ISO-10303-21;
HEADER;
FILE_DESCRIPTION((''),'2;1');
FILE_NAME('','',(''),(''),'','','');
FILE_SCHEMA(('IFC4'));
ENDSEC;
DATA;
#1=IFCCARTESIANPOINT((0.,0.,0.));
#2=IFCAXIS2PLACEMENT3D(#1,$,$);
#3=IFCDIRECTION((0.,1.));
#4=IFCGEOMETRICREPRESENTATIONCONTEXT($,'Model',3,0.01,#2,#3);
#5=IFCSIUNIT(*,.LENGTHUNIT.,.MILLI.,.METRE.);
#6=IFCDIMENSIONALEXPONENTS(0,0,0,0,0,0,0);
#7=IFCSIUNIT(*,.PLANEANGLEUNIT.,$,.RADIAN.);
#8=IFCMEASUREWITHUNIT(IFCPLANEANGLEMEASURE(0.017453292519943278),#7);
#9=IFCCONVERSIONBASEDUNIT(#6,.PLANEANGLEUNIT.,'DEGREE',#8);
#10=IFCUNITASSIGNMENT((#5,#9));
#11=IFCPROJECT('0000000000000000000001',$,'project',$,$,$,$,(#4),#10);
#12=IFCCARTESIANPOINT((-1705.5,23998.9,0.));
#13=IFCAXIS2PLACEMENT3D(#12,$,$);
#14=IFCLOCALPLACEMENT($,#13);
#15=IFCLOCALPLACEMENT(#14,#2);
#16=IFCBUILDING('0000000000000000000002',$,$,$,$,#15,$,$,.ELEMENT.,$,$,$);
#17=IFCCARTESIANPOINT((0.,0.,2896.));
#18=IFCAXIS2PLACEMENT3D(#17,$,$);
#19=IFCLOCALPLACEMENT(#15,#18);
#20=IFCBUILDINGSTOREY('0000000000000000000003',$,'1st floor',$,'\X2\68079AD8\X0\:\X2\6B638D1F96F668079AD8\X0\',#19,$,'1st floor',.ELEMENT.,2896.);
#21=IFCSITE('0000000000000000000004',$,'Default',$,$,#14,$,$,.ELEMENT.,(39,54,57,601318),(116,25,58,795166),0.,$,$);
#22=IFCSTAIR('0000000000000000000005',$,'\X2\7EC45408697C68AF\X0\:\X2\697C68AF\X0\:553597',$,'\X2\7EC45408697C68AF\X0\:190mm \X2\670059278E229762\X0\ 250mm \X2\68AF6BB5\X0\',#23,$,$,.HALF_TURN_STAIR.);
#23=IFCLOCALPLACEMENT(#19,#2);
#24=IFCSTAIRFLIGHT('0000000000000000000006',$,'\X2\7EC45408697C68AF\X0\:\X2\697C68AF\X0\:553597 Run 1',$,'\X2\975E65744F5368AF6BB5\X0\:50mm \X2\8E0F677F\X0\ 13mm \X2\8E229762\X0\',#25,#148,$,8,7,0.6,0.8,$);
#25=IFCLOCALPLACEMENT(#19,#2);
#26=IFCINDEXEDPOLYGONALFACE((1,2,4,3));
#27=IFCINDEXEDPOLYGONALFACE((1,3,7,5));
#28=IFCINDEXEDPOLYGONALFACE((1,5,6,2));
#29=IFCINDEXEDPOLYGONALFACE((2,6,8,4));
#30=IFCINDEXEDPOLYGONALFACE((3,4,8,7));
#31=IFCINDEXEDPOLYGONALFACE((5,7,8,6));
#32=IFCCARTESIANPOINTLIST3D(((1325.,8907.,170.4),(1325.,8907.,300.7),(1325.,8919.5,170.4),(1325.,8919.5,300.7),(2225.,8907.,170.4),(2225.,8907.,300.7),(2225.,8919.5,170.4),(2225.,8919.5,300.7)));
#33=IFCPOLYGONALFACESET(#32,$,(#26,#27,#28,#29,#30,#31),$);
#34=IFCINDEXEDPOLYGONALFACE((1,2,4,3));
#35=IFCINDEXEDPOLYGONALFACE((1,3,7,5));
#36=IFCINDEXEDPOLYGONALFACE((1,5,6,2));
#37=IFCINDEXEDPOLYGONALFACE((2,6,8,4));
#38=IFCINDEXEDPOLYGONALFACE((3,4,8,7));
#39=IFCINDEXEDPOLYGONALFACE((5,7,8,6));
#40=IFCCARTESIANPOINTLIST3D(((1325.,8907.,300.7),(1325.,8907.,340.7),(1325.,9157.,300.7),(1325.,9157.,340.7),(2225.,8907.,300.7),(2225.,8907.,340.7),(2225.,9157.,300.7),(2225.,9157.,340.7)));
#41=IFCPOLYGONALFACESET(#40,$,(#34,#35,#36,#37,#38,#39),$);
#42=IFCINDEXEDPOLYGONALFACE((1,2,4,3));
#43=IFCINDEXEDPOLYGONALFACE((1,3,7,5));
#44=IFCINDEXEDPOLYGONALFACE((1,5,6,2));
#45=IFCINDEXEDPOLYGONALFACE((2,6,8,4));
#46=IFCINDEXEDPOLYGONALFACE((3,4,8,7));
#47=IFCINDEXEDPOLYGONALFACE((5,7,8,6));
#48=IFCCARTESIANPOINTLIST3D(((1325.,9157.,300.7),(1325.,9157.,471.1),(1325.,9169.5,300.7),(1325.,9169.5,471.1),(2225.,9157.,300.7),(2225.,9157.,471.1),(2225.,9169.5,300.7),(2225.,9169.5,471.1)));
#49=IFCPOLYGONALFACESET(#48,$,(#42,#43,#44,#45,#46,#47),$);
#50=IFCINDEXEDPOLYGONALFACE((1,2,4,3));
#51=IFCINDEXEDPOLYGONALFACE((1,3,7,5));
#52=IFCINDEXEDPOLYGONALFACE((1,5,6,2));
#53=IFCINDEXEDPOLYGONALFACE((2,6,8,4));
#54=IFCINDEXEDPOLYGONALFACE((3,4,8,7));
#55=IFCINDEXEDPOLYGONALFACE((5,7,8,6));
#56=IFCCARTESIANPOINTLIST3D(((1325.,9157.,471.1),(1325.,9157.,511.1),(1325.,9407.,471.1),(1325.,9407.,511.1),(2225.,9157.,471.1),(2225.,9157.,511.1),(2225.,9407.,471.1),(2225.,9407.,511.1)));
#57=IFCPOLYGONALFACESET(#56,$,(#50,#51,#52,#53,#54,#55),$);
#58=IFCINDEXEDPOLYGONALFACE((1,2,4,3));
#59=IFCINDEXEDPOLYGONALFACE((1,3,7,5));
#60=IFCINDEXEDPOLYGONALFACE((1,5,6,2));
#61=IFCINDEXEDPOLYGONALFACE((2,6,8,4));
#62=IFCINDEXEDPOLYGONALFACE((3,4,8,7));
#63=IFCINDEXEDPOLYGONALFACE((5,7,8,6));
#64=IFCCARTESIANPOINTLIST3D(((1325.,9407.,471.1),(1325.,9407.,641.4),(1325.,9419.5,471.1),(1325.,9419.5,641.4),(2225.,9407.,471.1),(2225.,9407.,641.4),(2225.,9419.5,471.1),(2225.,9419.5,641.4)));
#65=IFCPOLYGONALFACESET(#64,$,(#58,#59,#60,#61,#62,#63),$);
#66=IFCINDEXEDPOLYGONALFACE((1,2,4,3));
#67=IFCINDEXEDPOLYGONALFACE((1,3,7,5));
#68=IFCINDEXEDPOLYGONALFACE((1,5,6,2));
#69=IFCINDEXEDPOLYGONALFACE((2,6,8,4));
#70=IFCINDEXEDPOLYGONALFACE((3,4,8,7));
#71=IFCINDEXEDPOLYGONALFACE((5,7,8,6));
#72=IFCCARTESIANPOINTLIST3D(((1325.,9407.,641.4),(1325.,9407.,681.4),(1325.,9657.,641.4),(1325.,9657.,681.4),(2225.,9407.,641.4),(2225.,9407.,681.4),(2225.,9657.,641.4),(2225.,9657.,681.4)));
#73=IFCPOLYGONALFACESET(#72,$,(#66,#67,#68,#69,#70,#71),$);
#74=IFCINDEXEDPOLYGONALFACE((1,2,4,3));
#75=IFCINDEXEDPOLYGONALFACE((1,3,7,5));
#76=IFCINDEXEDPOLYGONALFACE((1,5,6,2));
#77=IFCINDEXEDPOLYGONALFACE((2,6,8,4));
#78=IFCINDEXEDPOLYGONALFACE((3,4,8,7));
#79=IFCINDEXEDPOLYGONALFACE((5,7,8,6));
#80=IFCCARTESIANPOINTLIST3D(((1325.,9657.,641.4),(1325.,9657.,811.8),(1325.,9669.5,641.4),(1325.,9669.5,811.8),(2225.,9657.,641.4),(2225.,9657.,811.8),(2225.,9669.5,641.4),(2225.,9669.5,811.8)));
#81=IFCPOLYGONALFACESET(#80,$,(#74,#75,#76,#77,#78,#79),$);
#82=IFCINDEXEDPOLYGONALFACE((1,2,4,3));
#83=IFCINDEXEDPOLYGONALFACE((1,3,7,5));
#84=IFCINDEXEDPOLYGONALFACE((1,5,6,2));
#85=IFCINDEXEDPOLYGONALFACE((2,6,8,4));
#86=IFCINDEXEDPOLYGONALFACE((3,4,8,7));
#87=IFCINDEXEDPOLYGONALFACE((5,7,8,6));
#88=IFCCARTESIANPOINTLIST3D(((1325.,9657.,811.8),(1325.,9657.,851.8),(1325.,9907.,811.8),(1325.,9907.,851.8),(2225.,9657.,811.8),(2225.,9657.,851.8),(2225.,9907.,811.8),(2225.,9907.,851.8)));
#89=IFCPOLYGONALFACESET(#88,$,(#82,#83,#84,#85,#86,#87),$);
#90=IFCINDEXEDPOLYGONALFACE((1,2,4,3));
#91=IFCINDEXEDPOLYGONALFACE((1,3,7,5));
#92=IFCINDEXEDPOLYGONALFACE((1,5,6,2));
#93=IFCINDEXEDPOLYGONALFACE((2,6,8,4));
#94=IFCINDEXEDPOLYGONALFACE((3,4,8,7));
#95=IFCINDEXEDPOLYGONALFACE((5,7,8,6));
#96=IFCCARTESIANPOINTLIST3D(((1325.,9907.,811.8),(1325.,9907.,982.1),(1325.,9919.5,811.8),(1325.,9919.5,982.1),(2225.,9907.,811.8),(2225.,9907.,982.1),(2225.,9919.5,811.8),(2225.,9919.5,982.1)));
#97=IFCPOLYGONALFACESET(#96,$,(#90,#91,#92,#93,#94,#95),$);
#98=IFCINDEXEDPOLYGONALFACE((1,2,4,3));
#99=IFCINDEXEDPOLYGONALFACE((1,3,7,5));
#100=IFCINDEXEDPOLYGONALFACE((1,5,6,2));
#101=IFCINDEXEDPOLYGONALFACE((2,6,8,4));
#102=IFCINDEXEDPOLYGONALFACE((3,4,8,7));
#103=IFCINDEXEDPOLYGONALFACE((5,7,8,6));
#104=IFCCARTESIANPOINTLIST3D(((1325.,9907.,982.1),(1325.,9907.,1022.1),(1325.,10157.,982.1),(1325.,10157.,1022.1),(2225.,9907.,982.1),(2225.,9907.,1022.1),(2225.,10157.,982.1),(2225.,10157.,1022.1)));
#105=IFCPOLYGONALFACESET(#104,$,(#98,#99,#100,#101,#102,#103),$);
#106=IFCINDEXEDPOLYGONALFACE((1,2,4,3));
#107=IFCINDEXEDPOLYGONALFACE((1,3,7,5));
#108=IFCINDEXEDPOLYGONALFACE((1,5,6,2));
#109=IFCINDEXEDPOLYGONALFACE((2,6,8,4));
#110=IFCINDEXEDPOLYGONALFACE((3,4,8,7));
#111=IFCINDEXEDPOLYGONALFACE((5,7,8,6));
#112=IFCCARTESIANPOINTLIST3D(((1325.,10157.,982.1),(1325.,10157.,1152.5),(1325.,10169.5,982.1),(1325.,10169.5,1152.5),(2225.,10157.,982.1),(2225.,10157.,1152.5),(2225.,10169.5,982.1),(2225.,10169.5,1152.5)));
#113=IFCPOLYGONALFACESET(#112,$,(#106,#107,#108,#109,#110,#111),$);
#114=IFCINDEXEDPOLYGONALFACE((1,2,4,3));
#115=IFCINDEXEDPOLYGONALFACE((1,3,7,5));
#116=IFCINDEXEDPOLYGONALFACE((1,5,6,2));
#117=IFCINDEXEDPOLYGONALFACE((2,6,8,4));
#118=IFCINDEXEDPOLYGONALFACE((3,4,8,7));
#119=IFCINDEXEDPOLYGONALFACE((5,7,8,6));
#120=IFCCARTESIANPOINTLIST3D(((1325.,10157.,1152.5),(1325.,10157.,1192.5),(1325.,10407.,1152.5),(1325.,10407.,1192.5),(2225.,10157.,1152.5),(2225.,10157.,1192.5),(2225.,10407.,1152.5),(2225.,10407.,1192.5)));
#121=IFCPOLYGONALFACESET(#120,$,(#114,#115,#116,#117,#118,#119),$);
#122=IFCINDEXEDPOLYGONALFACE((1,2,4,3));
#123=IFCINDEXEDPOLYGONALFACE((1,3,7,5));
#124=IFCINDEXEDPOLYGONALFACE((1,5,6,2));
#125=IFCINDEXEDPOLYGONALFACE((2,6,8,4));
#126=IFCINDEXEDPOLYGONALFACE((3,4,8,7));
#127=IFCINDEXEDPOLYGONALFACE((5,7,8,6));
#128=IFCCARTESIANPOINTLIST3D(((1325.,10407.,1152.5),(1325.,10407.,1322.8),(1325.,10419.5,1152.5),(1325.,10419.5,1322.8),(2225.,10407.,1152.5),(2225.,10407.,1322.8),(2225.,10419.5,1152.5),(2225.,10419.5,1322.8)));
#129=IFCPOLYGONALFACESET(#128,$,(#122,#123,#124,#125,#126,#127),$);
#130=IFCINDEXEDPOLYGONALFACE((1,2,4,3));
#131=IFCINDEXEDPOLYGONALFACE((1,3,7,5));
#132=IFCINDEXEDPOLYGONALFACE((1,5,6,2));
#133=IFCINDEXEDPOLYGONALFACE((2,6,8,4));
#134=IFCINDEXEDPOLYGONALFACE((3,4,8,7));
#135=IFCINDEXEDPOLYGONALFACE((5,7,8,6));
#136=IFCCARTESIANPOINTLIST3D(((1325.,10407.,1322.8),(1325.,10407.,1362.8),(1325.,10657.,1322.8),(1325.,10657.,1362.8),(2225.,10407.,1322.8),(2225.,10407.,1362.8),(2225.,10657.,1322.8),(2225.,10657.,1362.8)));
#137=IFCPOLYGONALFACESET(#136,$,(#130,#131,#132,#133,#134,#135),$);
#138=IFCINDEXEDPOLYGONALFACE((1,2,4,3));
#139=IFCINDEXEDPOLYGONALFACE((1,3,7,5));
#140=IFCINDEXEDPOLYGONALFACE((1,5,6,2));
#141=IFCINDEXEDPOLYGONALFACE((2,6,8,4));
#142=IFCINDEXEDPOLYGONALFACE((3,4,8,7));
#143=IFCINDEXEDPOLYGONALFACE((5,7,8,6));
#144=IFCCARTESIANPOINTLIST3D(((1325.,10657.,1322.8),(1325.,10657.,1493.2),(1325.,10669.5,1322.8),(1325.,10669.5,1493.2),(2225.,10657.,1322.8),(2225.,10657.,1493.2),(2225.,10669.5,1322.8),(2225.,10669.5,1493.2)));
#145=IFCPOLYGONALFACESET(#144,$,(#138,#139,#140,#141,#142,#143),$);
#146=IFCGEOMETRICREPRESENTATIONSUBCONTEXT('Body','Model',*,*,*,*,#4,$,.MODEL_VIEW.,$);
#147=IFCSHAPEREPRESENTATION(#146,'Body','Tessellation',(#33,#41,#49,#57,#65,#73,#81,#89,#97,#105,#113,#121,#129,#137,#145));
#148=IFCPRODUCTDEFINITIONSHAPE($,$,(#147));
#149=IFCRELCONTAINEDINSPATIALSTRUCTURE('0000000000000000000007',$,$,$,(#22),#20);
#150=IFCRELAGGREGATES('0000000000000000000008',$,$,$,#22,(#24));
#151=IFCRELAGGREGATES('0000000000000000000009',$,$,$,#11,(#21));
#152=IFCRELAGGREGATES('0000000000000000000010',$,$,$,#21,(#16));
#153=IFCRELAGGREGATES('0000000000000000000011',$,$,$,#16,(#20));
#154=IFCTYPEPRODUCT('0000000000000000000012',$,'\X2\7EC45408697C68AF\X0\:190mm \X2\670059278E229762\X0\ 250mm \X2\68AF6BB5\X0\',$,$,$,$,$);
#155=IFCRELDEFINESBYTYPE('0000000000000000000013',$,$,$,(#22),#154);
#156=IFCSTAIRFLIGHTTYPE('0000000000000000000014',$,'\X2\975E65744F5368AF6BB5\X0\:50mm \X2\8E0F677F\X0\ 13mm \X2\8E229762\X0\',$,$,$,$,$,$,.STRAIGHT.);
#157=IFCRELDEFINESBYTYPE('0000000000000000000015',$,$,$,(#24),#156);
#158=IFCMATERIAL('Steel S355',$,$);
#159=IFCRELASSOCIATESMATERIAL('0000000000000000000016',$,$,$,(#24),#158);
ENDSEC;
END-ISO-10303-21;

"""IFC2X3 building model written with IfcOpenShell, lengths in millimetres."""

from ifc_helpers import new_model, entity, si_unit, converted_unit, direction, frame, frame_2d, origin, origin_2d_with_axis, place, context, subcontext, project, spatial, rectangle, extrude, material, type_object, element, aggregate, save


model = new_model("IFC2X3")

# Units and contexts
model_context = context("Model", 3, precision=0.01, world=origin(), true_north=direction((0.0, 1.0)))
body_context = subcontext(model_context, "Body", "Model", "MODEL_VIEW")
ifc_project = project(units=[si_unit("LENGTHUNIT", "METRE", prefix="MILLI"), converted_unit("PLANEANGLEUNIT", "DEGREE", entity("IfcPlaneAngleMeasure", 0.017453292519943278), si_unit("PLANEANGLEUNIT", "RADIAN"), dimensions=[0, 0, 0, 0, 0, 0, 0])], contexts=[model_context])

# Site, building, storey
site_placement = place(None, frame((-1705.5, 23998.9, 0.0)))
site = spatial("IfcSite", under=ifc_project, at=site_placement, Name="Default", CompositionType="ELEMENT", RefLatitude=(39, 54, 57, 601318), RefLongitude=(116, 25, 58, 795166), RefElevation=0.0)
building_placement = place(site_placement, origin())
building = spatial("IfcBuilding", under=site, at=building_placement, CompositionType="ELEMENT")
storey_placement = place(building_placement, frame((0.0, 0.0, 2896.0)))
storey = spatial("IfcBuildingStorey", under=building, at=storey_placement, Name="1st floor", ObjectType="标高:正负零标高", LongName="1st floor", CompositionType="ELEMENT", Elevation=2896.0)

# Stair
type_product = type_object("IfcTypeProduct", Name="组合楼梯:190mm 最大踢面 250mm 梯段")
stair_placement = place(storey_placement, origin())
stair = element("IfcStair", 1, at=stair_placement, inside=storey, type_object=type_product, Name="组合楼梯:楼梯:553597", ObjectType="组合楼梯:190mm 最大踢面 250mm 梯段", ShapeType="HALF_TURN_STAIR")
ifc_material_1 = material(Name="Steel S355")

# Stair flight
stair_flight_type = type_object("IfcStairFlightType", Name="非整体梯段:50mm 踏板 13mm 踢面", PredefinedType="STRAIGHT")
stair_flight_1_placement = place(stair_placement, origin())
stair_flight_1 = element("IfcStairFlight", 2, at=stair_flight_1_placement, type_object=stair_flight_type, material=ifc_material_1, Name="组合楼梯:楼梯:553597 Run 1", ObjectType="非整体梯段:50mm 踏板 13mm 踢面", NumberOfRiser=8, NumberOfTreads=7, RiserHeight=0.6, TreadLength=0.8, context=body_context, shape_type="SweptSolid", body=[
    extrude(rectangle(XDim=900.0, YDim=12.5, at=frame_2d((0.0, 0.0), x_axis=(1.0, 0.0))), frame((1775.0, 8913.2, 170.4), z_axis=(0.0, 0.0, 1.0), x_axis=(-1.0, 0.0, 0.0)), (0.0, 0.0, 1.0), 130.4),
    extrude(rectangle(XDim=250.0, YDim=900.0, at=frame_2d((0.0, 0.0), x_axis=(1.0, 0.0))), frame((1775.0, 9032.0, 300.7), z_axis=(0.0, 0.0, 1.0), x_axis=(0.0, -1.0, 0.0)), (0.0, 0.0, 1.0), 40.0),
    extrude(rectangle(XDim=900.0, YDim=12.5, at=frame_2d((0.0, 0.0), x_axis=(1.0, 0.0))), frame((1775.0, 9163.2, 300.7), z_axis=(0.0, 0.0, 1.0), x_axis=(-1.0, 0.0, 0.0)), (0.0, 0.0, 1.0), 170.4),
    extrude(rectangle(XDim=250.0, YDim=900.0, at=frame_2d((0.0, 0.0), x_axis=(1.0, 0.0))), frame((1775.0, 9282.0, 471.1), z_axis=(0.0, 0.0, 1.0), x_axis=(0.0, -1.0, 0.0)), (0.0, 0.0, 1.0), 40.0),
    extrude(rectangle(XDim=900.0, YDim=12.5, at=frame_2d((0.0, 0.0), x_axis=(1.0, 0.0))), frame((1775.0, 9413.2, 471.1), z_axis=(0.0, 0.0, 1.0), x_axis=(-1.0, 0.0, 0.0)), (0.0, 0.0, 1.0), 170.4),
    extrude(rectangle(XDim=250.0, YDim=900.0, at=frame_2d((0.0, 0.0), x_axis=(1.0, 0.0))), frame((1775.0, 9532.0, 641.4), z_axis=(0.0, 0.0, 1.0), x_axis=(0.0, -1.0, 0.0)), (0.0, 0.0, 1.0), 40.0),
    extrude(rectangle(XDim=900.0, YDim=12.5, at=frame_2d((0.0, 0.0), x_axis=(1.0, 0.0))), frame((1775.0, 9663.2, 641.4), z_axis=(0.0, 0.0, 1.0), x_axis=(-1.0, 0.0, 0.0)), (0.0, 0.0, 1.0), 170.4),
    extrude(rectangle(XDim=250.0, YDim=900.0, at=frame_2d((0.0, 0.0), x_axis=(1.0, 0.0))), frame((1775.0, 9782.0, 811.8), z_axis=(0.0, 0.0, 1.0), x_axis=(0.0, -1.0, 0.0)), (0.0, 0.0, 1.0), 40.0),
    extrude(rectangle(XDim=900.0, YDim=12.5, at=frame_2d((0.0, 0.0), x_axis=(1.0, 0.0))), frame((1775.0, 9913.2, 811.8), z_axis=(0.0, 0.0, 1.0), x_axis=(-1.0, 0.0, 0.0)), (0.0, 0.0, 1.0), 170.4),
    extrude(rectangle(XDim=250.0, YDim=900.0, at=frame_2d((0.0, 0.0), x_axis=(1.0, 0.0))), frame((1775.0, 10032.0, 982.1), z_axis=(0.0, 0.0, 1.0), x_axis=(0.0, -1.0, 0.0)), (0.0, 0.0, 1.0), 40.0),
    extrude(rectangle(XDim=900.0, YDim=12.5, at=frame_2d((0.0, 0.0), x_axis=(1.0, 0.0))), frame((1775.0, 10163.2, 982.1), z_axis=(0.0, 0.0, 1.0), x_axis=(-1.0, 0.0, 0.0)), (0.0, 0.0, 1.0), 170.4),
    extrude(rectangle(XDim=250.0, YDim=900.0, at=frame_2d((0.0, 0.0), x_axis=(1.0, 0.0))), frame((1775.0, 10282.0, 1152.5), z_axis=(0.0, 0.0, 1.0), x_axis=(0.0, -1.0, 0.0)), (0.0, 0.0, 1.0), 40.0),
    extrude(rectangle(XDim=900.0, YDim=12.5, at=origin_2d_with_axis()), frame((1775.0, 10413.2, 1152.5), z_axis=(0.0, 0.0, 1.0), x_axis=(-1.0, 0.0, 0.0)), (0.0, 0.0, 1.0), 170.4),
    extrude(rectangle(XDim=250.0, YDim=900.0, at=frame_2d((0.0, 0.0), x_axis=(1.0, 0.0))), frame((1775.0, 10532.0, 1322.8), z_axis=(0.0, 0.0, 1.0), x_axis=(0.0, -1.0, 0.0)), (0.0, 0.0, 1.0), 40.0),
    extrude(rectangle(XDim=900.0, YDim=12.5, at=origin_2d_with_axis()), frame((1775.0, 10663.2, 1322.8), z_axis=(0.0, 0.0, 1.0), x_axis=(-1.0, 0.0, 0.0)), (0.0, 0.0, 1.0), 170.4),
])
aggregate(stair, [stair_flight_1])

save(model, "model.ifc")
